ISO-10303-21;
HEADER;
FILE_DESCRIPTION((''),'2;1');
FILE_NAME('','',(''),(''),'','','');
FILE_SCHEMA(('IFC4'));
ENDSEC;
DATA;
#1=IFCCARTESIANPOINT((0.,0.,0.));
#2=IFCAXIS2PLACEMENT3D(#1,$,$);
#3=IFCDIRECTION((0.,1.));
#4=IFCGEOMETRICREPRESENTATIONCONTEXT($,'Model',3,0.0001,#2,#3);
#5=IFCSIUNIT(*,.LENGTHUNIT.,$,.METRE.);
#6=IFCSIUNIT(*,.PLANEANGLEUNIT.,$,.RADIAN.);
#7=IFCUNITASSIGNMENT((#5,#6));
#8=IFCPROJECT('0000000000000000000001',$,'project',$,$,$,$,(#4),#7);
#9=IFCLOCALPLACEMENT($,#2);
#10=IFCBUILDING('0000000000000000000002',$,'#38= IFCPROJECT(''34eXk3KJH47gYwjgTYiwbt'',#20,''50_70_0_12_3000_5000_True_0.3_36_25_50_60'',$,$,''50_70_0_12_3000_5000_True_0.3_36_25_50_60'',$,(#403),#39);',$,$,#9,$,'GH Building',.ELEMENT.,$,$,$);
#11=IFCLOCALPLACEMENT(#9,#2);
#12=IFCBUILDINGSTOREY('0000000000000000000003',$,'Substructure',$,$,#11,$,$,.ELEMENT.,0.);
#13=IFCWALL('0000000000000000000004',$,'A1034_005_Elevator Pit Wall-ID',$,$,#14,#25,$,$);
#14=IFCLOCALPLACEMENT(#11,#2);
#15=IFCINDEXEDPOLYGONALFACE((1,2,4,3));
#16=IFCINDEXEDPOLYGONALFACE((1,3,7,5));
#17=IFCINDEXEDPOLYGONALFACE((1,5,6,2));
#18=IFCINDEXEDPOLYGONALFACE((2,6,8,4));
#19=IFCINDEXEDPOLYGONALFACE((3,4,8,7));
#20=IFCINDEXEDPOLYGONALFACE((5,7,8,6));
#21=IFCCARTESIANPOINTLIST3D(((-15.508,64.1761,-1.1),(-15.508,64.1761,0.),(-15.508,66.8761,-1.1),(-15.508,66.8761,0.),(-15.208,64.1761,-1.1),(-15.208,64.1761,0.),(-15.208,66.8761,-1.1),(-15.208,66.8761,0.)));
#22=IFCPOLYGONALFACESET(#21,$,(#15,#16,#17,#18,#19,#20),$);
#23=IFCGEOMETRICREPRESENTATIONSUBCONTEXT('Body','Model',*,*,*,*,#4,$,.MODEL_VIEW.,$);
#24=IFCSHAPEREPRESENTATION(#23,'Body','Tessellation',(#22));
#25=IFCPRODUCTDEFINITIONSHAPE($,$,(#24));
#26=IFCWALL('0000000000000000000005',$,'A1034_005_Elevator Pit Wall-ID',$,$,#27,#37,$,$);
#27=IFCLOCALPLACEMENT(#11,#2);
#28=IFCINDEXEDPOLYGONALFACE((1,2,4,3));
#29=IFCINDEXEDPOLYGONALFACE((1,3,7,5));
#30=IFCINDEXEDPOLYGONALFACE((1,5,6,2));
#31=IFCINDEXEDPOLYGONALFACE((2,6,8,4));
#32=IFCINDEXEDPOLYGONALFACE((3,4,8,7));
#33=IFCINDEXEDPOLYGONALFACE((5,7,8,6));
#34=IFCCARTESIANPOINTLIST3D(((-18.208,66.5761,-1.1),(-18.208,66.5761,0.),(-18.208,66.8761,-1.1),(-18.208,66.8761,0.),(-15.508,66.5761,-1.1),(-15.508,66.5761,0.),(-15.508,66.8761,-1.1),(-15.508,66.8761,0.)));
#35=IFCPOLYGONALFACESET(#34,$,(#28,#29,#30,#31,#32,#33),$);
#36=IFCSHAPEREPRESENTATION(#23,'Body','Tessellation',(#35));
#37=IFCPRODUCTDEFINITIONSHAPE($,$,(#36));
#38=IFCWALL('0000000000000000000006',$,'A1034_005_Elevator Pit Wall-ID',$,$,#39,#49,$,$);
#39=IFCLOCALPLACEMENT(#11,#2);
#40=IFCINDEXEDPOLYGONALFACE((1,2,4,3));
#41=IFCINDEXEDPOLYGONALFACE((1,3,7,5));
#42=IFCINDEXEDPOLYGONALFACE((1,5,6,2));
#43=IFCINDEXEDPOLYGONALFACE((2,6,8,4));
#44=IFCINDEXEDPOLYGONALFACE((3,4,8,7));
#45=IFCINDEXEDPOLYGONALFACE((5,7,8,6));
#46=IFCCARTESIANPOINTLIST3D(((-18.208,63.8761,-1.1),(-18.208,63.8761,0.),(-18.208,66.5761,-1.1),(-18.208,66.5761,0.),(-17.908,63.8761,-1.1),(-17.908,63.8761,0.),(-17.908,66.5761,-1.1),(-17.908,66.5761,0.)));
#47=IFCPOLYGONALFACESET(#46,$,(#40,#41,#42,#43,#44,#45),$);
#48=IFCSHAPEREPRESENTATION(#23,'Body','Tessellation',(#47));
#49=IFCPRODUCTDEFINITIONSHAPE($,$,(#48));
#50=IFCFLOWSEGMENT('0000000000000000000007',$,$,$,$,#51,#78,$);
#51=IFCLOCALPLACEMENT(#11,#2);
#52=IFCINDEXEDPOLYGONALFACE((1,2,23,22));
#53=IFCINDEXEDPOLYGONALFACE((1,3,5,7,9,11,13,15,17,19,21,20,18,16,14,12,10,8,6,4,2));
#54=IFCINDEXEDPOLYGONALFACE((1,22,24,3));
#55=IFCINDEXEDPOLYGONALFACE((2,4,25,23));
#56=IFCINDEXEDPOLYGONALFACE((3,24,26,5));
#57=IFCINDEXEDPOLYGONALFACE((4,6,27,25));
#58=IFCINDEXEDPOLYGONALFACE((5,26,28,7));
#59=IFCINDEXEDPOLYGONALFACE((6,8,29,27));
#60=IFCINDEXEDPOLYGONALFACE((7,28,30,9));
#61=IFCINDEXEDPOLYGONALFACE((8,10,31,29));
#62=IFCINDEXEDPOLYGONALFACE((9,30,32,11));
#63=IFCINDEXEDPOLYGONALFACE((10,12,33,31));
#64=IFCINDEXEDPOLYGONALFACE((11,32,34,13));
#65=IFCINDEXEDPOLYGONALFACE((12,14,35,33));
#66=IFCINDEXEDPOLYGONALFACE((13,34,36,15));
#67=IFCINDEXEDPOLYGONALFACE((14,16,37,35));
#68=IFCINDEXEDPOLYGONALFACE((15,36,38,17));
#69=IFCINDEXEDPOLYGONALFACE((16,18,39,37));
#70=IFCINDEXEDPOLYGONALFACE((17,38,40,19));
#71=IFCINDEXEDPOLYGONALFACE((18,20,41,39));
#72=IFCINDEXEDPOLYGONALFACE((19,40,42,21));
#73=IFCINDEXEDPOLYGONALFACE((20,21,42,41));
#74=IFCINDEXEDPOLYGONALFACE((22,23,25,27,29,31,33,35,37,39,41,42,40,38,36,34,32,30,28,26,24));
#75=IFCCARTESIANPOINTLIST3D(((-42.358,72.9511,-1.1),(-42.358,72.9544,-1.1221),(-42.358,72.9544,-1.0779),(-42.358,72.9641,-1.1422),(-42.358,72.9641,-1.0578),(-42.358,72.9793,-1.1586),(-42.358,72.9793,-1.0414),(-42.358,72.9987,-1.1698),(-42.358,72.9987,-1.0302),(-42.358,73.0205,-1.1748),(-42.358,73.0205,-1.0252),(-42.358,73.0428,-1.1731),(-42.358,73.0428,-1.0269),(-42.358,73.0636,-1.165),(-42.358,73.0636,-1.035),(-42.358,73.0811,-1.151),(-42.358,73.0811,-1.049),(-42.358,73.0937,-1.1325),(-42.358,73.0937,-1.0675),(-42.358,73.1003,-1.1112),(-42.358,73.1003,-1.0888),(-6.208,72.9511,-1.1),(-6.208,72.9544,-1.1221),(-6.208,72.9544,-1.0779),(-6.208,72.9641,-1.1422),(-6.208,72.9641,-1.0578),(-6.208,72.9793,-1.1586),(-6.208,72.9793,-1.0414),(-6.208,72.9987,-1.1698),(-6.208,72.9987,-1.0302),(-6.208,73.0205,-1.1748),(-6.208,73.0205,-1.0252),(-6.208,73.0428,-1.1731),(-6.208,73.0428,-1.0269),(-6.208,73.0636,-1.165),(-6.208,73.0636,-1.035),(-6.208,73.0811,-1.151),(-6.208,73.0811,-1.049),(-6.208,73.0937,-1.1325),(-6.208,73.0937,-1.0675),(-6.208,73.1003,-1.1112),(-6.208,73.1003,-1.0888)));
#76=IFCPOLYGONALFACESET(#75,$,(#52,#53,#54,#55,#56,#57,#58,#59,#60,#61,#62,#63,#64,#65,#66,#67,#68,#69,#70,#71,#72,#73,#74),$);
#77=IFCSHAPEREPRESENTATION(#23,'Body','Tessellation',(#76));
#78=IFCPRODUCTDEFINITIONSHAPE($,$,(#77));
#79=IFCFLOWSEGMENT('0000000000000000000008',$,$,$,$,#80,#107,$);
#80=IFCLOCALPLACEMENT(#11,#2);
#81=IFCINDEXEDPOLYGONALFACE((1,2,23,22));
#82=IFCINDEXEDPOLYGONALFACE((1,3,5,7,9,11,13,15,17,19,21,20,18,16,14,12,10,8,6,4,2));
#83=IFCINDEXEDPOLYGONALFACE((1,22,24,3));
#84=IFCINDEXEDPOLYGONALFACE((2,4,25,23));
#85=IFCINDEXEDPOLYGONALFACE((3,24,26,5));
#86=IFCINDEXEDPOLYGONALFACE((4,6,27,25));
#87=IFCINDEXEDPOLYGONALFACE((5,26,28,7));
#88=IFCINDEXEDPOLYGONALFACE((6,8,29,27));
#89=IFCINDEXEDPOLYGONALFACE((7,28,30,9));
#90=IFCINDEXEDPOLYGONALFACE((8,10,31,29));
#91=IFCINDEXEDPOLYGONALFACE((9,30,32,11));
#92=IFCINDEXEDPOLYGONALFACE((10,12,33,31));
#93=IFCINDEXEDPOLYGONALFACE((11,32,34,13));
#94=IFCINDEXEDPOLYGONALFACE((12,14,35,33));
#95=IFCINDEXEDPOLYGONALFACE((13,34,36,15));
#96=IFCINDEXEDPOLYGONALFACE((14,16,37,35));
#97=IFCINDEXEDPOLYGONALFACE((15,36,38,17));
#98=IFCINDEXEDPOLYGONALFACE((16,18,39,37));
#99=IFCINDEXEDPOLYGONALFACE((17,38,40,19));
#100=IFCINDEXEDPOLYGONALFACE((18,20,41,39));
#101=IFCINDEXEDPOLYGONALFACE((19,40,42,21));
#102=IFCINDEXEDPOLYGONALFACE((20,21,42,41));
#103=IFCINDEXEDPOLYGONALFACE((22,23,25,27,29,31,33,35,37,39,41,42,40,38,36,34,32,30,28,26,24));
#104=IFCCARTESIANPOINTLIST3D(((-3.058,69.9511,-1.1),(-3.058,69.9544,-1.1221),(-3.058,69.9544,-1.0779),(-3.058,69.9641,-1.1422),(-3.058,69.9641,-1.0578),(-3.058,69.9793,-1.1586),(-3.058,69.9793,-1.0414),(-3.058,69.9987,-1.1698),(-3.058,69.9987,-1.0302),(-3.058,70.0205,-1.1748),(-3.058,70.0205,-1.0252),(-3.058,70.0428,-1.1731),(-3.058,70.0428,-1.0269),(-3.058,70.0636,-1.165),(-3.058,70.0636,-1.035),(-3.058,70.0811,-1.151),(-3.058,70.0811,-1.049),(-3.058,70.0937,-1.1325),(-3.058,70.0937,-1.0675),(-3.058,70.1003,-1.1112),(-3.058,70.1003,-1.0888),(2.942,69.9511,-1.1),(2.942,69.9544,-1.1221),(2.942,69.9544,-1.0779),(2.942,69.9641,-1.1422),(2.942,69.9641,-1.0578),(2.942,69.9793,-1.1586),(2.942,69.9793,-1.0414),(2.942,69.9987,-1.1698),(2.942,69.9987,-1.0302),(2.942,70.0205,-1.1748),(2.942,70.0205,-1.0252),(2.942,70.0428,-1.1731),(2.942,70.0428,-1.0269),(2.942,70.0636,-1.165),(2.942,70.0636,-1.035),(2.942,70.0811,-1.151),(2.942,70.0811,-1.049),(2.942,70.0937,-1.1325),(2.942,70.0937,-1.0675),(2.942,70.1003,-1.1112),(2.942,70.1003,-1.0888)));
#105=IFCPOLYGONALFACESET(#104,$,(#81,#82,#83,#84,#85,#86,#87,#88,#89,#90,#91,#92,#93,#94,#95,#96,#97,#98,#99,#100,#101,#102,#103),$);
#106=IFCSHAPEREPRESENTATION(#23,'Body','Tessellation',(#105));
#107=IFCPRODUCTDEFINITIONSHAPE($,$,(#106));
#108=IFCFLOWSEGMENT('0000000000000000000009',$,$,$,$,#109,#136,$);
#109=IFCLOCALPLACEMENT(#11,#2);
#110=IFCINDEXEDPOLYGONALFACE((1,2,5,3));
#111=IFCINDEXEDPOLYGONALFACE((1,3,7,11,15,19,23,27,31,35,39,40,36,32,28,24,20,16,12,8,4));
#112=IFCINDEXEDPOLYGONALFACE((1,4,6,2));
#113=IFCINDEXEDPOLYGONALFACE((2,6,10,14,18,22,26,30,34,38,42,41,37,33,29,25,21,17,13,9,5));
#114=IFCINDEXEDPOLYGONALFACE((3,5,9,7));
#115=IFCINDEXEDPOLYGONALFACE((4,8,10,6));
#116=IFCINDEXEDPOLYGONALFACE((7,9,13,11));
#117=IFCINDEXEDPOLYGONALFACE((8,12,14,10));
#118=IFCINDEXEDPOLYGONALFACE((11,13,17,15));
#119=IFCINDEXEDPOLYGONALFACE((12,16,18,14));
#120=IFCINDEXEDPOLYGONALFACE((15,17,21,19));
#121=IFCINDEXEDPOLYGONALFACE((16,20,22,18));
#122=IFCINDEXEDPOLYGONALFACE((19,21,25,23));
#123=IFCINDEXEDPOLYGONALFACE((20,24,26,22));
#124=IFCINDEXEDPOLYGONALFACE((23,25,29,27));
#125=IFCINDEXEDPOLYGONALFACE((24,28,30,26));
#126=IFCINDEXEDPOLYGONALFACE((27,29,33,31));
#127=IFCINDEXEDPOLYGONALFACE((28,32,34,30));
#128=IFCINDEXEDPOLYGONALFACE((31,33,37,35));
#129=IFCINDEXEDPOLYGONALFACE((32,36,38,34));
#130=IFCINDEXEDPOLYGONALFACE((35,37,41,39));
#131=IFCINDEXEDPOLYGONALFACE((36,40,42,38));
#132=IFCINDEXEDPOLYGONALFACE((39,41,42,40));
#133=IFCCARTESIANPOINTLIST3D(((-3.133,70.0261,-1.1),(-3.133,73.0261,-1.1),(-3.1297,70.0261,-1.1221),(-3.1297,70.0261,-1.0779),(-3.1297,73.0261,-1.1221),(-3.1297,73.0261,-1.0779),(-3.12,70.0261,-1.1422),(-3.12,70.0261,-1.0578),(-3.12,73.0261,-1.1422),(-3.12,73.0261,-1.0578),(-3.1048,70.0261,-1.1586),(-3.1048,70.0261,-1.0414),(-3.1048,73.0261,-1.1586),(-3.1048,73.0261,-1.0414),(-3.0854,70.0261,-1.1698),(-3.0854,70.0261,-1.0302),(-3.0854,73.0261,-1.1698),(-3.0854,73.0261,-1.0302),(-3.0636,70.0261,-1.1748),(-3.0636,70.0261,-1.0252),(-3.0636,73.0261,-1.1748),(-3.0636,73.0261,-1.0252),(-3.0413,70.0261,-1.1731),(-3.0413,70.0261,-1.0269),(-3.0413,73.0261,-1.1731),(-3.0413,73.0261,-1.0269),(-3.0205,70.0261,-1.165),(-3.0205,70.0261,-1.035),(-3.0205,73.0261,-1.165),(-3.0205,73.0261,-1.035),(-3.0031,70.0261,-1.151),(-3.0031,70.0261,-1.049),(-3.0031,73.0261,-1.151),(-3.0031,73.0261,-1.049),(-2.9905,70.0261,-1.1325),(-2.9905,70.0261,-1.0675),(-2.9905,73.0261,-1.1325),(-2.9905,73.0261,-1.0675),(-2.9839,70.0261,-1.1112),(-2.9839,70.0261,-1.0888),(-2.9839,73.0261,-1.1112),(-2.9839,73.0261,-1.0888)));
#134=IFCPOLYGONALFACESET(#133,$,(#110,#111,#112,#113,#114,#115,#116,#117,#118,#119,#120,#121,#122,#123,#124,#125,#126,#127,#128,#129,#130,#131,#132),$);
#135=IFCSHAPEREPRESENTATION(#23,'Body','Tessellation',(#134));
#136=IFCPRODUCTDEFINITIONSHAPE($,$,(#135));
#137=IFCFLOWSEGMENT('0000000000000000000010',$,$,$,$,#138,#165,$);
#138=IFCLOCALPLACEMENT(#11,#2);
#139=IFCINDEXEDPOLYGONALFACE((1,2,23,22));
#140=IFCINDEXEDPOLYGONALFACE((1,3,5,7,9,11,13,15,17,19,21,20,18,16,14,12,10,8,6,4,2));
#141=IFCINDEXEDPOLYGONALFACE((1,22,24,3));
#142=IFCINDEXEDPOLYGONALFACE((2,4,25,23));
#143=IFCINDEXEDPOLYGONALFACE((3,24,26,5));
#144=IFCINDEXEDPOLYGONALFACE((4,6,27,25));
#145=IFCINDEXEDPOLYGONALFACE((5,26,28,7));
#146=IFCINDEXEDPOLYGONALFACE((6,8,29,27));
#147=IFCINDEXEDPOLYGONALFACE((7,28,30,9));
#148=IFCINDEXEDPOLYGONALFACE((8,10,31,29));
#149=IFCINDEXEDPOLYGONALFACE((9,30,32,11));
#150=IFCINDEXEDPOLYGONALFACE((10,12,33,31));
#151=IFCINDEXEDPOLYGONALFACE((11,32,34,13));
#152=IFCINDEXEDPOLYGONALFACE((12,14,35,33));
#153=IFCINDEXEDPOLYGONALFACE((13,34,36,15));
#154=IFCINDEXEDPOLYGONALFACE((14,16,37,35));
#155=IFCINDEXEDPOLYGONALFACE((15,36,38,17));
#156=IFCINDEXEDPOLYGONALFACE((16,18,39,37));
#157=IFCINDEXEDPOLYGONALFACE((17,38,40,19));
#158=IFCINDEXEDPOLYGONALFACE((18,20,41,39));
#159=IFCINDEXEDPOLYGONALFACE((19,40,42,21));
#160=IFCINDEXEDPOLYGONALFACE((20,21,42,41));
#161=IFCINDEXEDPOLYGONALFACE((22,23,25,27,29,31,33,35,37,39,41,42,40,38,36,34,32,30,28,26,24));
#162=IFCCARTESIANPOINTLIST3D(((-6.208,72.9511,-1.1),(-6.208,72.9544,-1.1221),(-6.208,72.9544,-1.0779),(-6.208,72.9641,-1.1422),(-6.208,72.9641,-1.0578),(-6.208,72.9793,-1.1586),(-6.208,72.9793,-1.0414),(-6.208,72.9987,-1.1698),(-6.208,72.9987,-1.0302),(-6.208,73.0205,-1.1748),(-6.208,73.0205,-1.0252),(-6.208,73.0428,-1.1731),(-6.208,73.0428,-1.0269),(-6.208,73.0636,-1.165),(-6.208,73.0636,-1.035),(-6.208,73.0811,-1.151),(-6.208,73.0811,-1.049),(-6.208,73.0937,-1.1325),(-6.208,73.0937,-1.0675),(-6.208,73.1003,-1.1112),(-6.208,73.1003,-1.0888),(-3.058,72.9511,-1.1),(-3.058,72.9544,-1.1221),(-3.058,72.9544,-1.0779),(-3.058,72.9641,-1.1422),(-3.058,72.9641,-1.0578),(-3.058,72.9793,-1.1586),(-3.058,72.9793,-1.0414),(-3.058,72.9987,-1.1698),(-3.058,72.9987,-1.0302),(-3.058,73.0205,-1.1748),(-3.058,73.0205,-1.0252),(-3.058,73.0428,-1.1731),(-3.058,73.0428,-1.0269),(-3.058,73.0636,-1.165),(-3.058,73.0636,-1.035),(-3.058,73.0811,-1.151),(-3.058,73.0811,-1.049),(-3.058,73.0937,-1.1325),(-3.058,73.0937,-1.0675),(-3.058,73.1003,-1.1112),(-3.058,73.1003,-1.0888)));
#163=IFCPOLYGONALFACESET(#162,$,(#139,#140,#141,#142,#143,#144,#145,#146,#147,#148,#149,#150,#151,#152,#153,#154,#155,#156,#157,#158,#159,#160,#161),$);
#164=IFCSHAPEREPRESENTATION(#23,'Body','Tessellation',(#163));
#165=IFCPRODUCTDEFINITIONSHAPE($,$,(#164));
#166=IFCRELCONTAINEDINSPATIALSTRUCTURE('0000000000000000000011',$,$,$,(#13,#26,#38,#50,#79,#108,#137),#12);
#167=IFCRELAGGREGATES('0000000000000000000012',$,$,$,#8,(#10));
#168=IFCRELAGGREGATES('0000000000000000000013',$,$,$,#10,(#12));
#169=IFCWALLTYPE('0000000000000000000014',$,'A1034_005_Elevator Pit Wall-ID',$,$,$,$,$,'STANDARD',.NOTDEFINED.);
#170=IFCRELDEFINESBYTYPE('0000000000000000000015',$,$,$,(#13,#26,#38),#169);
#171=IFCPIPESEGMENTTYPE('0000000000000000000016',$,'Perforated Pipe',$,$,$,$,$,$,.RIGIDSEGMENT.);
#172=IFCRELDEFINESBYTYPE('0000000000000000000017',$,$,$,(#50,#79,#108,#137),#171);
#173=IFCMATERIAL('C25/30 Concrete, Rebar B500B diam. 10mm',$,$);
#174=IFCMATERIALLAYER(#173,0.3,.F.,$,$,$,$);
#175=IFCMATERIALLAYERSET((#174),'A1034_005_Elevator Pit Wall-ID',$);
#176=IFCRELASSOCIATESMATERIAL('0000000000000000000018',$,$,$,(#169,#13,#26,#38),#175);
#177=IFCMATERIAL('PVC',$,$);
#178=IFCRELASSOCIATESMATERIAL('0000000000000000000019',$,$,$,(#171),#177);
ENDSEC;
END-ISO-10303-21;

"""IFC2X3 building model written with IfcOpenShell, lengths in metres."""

from ifc_helpers import new_model, si_unit, direction, frame, frame_2d, origin, origin_2d, place, context, subcontext, project, spatial, rectangle, circle, extrude, material, layer, layer_set, layer_usage, type_object, element, save


model = new_model("IFC2X3")

# Units and contexts
model_context = context("Model", 3, precision=0.0001, world=origin(), true_north=direction((0.0, 1.0)))
body_context = subcontext(model_context, "Body", "Model", "MODEL_VIEW")
ifc_project = project(units=[si_unit("LENGTHUNIT", "METRE"), si_unit("PLANEANGLEUNIT", "RADIAN")], contexts=[model_context])

# Building, storey
building_placement = place(None, origin())
building = spatial("IfcBuilding", under=ifc_project, at=building_placement, Name="#38= IFCPROJECT('34eXk3KJH47gYwjgTYiwbt',#20,'50_70_0_12_3000_5000_True_0.3_36_25_50_60',$,$,'50_70_0_12_3000_5000_True_0.3_36_25_50_60',$,(#403),#39);", LongName="GH Building", CompositionType="ELEMENT")
storey_placement = place(building_placement, origin())
storey = spatial("IfcBuildingStorey", under=building, at=storey_placement, Name="Substructure", CompositionType="ELEMENT", Elevation=0.0)

# Walls
ifc_material_1 = material(Name="C25/30 Concrete, Rebar B500B diam. 10mm")
ifc_layer = layer(ifc_material_1, 0.3, ventilated=False)
ifc_layer_set = layer_set([ifc_layer], Name="A1034_005_Elevator Pit Wall-ID")
wall_type = type_object("IfcWallType", Name="A1034_005_Elevator Pit Wall-ID", ElementType="STANDARD", PredefinedType="NOTDEFINED", material=ifc_layer_set)
ifc_layer_usage_1 = layer_usage(ifc_layer_set, "AXIS2", "POSITIVE", 0.0)
wall_1_placement = place(storey_placement, frame((-15.208, 64.1761, -1.1), z_axis=(0.0, 0.0, 1.0), x_axis=(0.0, 1.0, 0.0)))
element("IfcWall", 1, at=wall_1_placement, inside=storey, type_object=wall_type, material=ifc_layer_usage_1, Name="A1034_005_Elevator Pit Wall-ID", context=body_context, shape_type="SweptSolid", body=[
    extrude(rectangle(XDim=2.7, YDim=0.3, at=frame_2d((1.35, 0.15))), origin(), (0.0, 0.0, 1.0), 1.1),
])
ifc_layer_usage_2 = layer_usage(ifc_layer_set, "AXIS2", "POSITIVE", 0.0)
wall_2_placement = place(storey_placement, frame((-15.508, 66.8761, -1.1), z_axis=(0.0, 0.0, 1.0), x_axis=(-1.0, 0.0, 0.0)))
element("IfcWall", 2, at=wall_2_placement, inside=storey, type_object=wall_type, material=ifc_layer_usage_2, Name="A1034_005_Elevator Pit Wall-ID", context=body_context, shape_type="SweptSolid", body=[
    extrude(rectangle(XDim=2.7, YDim=0.3, at=frame_2d((1.35, 0.15))), origin(), (0.0, 0.0, 1.0), 1.1),
])
ifc_layer_usage_3 = layer_usage(ifc_layer_set, "AXIS2", "POSITIVE", 0.0)
wall_3_placement = place(storey_placement, frame((-18.208, 66.5761, -1.1), z_axis=(0.0, 0.0, 1.0), x_axis=(0.0, -1.0, 0.0)))
element("IfcWall", 3, at=wall_3_placement, inside=storey, type_object=wall_type, material=ifc_layer_usage_3, Name="A1034_005_Elevator Pit Wall-ID", context=body_context, shape_type="SweptSolid", body=[
    extrude(rectangle(XDim=2.7, YDim=0.3, at=frame_2d((1.35, 0.15))), origin(), (0.0, 0.0, 1.0), 1.1),
])

# Flow segments
ifc_material_2 = material(Name="PVC")
pipe_segment_type = type_object("IfcPipeSegmentType", Name="Perforated Pipe", PredefinedType="RIGIDSEGMENT", material=ifc_material_2)
flow_segment_1_placement = place(storey_placement, frame((-6.208, 73.0261, -1.1), z_axis=(-1.0, 0.0, 0.0), x_axis=(0.0, -1.0, 0.0)))
element("IfcFlowSegment", 4, at=flow_segment_1_placement, inside=storey, type_object=pipe_segment_type, context=body_context, shape_type="SweptSolid", body=[
    extrude(circle(Radius=0.075, at=origin_2d()), origin(), (0.0, 0.0, 1.0), 36.15),
])
flow_segment_2_placement = place(storey_placement, frame((2.942, 70.0261, -1.1), z_axis=(-1.0, 0.0, 0.0), x_axis=(0.0, -1.0, 0.0)))
element("IfcFlowSegment", 5, at=flow_segment_2_placement, inside=storey, type_object=pipe_segment_type, context=body_context, shape_type="SweptSolid", body=[
    extrude(circle(Radius=0.075, at=origin_2d()), origin(), (0.0, 0.0, 1.0), 6.0),
])
flow_segment_3_placement = place(storey_placement, frame((-3.058, 70.0261, -1.1), z_axis=(0.0, 1.0, 0.0), x_axis=(-1.0, 0.0, 0.0)))
element("IfcFlowSegment", 6, at=flow_segment_3_placement, inside=storey, type_object=pipe_segment_type, context=body_context, shape_type="SweptSolid", body=[
    extrude(circle(Radius=0.075, at=origin_2d()), origin(), (0.0, 0.0, 1.0), 3.0),
])
flow_segment_4_placement = place(storey_placement, frame((-3.058, 73.0261, -1.1), z_axis=(-1.0, 0.0, 0.0), x_axis=(0.0, -1.0, 0.0)))
element("IfcFlowSegment", 7, at=flow_segment_4_placement, inside=storey, type_object=pipe_segment_type, context=body_context, shape_type="SweptSolid", body=[
    extrude(circle(Radius=0.075, at=origin_2d()), origin(), (0.0, 0.0, 1.0), 3.15),
])

save(model, "model.ifc")
